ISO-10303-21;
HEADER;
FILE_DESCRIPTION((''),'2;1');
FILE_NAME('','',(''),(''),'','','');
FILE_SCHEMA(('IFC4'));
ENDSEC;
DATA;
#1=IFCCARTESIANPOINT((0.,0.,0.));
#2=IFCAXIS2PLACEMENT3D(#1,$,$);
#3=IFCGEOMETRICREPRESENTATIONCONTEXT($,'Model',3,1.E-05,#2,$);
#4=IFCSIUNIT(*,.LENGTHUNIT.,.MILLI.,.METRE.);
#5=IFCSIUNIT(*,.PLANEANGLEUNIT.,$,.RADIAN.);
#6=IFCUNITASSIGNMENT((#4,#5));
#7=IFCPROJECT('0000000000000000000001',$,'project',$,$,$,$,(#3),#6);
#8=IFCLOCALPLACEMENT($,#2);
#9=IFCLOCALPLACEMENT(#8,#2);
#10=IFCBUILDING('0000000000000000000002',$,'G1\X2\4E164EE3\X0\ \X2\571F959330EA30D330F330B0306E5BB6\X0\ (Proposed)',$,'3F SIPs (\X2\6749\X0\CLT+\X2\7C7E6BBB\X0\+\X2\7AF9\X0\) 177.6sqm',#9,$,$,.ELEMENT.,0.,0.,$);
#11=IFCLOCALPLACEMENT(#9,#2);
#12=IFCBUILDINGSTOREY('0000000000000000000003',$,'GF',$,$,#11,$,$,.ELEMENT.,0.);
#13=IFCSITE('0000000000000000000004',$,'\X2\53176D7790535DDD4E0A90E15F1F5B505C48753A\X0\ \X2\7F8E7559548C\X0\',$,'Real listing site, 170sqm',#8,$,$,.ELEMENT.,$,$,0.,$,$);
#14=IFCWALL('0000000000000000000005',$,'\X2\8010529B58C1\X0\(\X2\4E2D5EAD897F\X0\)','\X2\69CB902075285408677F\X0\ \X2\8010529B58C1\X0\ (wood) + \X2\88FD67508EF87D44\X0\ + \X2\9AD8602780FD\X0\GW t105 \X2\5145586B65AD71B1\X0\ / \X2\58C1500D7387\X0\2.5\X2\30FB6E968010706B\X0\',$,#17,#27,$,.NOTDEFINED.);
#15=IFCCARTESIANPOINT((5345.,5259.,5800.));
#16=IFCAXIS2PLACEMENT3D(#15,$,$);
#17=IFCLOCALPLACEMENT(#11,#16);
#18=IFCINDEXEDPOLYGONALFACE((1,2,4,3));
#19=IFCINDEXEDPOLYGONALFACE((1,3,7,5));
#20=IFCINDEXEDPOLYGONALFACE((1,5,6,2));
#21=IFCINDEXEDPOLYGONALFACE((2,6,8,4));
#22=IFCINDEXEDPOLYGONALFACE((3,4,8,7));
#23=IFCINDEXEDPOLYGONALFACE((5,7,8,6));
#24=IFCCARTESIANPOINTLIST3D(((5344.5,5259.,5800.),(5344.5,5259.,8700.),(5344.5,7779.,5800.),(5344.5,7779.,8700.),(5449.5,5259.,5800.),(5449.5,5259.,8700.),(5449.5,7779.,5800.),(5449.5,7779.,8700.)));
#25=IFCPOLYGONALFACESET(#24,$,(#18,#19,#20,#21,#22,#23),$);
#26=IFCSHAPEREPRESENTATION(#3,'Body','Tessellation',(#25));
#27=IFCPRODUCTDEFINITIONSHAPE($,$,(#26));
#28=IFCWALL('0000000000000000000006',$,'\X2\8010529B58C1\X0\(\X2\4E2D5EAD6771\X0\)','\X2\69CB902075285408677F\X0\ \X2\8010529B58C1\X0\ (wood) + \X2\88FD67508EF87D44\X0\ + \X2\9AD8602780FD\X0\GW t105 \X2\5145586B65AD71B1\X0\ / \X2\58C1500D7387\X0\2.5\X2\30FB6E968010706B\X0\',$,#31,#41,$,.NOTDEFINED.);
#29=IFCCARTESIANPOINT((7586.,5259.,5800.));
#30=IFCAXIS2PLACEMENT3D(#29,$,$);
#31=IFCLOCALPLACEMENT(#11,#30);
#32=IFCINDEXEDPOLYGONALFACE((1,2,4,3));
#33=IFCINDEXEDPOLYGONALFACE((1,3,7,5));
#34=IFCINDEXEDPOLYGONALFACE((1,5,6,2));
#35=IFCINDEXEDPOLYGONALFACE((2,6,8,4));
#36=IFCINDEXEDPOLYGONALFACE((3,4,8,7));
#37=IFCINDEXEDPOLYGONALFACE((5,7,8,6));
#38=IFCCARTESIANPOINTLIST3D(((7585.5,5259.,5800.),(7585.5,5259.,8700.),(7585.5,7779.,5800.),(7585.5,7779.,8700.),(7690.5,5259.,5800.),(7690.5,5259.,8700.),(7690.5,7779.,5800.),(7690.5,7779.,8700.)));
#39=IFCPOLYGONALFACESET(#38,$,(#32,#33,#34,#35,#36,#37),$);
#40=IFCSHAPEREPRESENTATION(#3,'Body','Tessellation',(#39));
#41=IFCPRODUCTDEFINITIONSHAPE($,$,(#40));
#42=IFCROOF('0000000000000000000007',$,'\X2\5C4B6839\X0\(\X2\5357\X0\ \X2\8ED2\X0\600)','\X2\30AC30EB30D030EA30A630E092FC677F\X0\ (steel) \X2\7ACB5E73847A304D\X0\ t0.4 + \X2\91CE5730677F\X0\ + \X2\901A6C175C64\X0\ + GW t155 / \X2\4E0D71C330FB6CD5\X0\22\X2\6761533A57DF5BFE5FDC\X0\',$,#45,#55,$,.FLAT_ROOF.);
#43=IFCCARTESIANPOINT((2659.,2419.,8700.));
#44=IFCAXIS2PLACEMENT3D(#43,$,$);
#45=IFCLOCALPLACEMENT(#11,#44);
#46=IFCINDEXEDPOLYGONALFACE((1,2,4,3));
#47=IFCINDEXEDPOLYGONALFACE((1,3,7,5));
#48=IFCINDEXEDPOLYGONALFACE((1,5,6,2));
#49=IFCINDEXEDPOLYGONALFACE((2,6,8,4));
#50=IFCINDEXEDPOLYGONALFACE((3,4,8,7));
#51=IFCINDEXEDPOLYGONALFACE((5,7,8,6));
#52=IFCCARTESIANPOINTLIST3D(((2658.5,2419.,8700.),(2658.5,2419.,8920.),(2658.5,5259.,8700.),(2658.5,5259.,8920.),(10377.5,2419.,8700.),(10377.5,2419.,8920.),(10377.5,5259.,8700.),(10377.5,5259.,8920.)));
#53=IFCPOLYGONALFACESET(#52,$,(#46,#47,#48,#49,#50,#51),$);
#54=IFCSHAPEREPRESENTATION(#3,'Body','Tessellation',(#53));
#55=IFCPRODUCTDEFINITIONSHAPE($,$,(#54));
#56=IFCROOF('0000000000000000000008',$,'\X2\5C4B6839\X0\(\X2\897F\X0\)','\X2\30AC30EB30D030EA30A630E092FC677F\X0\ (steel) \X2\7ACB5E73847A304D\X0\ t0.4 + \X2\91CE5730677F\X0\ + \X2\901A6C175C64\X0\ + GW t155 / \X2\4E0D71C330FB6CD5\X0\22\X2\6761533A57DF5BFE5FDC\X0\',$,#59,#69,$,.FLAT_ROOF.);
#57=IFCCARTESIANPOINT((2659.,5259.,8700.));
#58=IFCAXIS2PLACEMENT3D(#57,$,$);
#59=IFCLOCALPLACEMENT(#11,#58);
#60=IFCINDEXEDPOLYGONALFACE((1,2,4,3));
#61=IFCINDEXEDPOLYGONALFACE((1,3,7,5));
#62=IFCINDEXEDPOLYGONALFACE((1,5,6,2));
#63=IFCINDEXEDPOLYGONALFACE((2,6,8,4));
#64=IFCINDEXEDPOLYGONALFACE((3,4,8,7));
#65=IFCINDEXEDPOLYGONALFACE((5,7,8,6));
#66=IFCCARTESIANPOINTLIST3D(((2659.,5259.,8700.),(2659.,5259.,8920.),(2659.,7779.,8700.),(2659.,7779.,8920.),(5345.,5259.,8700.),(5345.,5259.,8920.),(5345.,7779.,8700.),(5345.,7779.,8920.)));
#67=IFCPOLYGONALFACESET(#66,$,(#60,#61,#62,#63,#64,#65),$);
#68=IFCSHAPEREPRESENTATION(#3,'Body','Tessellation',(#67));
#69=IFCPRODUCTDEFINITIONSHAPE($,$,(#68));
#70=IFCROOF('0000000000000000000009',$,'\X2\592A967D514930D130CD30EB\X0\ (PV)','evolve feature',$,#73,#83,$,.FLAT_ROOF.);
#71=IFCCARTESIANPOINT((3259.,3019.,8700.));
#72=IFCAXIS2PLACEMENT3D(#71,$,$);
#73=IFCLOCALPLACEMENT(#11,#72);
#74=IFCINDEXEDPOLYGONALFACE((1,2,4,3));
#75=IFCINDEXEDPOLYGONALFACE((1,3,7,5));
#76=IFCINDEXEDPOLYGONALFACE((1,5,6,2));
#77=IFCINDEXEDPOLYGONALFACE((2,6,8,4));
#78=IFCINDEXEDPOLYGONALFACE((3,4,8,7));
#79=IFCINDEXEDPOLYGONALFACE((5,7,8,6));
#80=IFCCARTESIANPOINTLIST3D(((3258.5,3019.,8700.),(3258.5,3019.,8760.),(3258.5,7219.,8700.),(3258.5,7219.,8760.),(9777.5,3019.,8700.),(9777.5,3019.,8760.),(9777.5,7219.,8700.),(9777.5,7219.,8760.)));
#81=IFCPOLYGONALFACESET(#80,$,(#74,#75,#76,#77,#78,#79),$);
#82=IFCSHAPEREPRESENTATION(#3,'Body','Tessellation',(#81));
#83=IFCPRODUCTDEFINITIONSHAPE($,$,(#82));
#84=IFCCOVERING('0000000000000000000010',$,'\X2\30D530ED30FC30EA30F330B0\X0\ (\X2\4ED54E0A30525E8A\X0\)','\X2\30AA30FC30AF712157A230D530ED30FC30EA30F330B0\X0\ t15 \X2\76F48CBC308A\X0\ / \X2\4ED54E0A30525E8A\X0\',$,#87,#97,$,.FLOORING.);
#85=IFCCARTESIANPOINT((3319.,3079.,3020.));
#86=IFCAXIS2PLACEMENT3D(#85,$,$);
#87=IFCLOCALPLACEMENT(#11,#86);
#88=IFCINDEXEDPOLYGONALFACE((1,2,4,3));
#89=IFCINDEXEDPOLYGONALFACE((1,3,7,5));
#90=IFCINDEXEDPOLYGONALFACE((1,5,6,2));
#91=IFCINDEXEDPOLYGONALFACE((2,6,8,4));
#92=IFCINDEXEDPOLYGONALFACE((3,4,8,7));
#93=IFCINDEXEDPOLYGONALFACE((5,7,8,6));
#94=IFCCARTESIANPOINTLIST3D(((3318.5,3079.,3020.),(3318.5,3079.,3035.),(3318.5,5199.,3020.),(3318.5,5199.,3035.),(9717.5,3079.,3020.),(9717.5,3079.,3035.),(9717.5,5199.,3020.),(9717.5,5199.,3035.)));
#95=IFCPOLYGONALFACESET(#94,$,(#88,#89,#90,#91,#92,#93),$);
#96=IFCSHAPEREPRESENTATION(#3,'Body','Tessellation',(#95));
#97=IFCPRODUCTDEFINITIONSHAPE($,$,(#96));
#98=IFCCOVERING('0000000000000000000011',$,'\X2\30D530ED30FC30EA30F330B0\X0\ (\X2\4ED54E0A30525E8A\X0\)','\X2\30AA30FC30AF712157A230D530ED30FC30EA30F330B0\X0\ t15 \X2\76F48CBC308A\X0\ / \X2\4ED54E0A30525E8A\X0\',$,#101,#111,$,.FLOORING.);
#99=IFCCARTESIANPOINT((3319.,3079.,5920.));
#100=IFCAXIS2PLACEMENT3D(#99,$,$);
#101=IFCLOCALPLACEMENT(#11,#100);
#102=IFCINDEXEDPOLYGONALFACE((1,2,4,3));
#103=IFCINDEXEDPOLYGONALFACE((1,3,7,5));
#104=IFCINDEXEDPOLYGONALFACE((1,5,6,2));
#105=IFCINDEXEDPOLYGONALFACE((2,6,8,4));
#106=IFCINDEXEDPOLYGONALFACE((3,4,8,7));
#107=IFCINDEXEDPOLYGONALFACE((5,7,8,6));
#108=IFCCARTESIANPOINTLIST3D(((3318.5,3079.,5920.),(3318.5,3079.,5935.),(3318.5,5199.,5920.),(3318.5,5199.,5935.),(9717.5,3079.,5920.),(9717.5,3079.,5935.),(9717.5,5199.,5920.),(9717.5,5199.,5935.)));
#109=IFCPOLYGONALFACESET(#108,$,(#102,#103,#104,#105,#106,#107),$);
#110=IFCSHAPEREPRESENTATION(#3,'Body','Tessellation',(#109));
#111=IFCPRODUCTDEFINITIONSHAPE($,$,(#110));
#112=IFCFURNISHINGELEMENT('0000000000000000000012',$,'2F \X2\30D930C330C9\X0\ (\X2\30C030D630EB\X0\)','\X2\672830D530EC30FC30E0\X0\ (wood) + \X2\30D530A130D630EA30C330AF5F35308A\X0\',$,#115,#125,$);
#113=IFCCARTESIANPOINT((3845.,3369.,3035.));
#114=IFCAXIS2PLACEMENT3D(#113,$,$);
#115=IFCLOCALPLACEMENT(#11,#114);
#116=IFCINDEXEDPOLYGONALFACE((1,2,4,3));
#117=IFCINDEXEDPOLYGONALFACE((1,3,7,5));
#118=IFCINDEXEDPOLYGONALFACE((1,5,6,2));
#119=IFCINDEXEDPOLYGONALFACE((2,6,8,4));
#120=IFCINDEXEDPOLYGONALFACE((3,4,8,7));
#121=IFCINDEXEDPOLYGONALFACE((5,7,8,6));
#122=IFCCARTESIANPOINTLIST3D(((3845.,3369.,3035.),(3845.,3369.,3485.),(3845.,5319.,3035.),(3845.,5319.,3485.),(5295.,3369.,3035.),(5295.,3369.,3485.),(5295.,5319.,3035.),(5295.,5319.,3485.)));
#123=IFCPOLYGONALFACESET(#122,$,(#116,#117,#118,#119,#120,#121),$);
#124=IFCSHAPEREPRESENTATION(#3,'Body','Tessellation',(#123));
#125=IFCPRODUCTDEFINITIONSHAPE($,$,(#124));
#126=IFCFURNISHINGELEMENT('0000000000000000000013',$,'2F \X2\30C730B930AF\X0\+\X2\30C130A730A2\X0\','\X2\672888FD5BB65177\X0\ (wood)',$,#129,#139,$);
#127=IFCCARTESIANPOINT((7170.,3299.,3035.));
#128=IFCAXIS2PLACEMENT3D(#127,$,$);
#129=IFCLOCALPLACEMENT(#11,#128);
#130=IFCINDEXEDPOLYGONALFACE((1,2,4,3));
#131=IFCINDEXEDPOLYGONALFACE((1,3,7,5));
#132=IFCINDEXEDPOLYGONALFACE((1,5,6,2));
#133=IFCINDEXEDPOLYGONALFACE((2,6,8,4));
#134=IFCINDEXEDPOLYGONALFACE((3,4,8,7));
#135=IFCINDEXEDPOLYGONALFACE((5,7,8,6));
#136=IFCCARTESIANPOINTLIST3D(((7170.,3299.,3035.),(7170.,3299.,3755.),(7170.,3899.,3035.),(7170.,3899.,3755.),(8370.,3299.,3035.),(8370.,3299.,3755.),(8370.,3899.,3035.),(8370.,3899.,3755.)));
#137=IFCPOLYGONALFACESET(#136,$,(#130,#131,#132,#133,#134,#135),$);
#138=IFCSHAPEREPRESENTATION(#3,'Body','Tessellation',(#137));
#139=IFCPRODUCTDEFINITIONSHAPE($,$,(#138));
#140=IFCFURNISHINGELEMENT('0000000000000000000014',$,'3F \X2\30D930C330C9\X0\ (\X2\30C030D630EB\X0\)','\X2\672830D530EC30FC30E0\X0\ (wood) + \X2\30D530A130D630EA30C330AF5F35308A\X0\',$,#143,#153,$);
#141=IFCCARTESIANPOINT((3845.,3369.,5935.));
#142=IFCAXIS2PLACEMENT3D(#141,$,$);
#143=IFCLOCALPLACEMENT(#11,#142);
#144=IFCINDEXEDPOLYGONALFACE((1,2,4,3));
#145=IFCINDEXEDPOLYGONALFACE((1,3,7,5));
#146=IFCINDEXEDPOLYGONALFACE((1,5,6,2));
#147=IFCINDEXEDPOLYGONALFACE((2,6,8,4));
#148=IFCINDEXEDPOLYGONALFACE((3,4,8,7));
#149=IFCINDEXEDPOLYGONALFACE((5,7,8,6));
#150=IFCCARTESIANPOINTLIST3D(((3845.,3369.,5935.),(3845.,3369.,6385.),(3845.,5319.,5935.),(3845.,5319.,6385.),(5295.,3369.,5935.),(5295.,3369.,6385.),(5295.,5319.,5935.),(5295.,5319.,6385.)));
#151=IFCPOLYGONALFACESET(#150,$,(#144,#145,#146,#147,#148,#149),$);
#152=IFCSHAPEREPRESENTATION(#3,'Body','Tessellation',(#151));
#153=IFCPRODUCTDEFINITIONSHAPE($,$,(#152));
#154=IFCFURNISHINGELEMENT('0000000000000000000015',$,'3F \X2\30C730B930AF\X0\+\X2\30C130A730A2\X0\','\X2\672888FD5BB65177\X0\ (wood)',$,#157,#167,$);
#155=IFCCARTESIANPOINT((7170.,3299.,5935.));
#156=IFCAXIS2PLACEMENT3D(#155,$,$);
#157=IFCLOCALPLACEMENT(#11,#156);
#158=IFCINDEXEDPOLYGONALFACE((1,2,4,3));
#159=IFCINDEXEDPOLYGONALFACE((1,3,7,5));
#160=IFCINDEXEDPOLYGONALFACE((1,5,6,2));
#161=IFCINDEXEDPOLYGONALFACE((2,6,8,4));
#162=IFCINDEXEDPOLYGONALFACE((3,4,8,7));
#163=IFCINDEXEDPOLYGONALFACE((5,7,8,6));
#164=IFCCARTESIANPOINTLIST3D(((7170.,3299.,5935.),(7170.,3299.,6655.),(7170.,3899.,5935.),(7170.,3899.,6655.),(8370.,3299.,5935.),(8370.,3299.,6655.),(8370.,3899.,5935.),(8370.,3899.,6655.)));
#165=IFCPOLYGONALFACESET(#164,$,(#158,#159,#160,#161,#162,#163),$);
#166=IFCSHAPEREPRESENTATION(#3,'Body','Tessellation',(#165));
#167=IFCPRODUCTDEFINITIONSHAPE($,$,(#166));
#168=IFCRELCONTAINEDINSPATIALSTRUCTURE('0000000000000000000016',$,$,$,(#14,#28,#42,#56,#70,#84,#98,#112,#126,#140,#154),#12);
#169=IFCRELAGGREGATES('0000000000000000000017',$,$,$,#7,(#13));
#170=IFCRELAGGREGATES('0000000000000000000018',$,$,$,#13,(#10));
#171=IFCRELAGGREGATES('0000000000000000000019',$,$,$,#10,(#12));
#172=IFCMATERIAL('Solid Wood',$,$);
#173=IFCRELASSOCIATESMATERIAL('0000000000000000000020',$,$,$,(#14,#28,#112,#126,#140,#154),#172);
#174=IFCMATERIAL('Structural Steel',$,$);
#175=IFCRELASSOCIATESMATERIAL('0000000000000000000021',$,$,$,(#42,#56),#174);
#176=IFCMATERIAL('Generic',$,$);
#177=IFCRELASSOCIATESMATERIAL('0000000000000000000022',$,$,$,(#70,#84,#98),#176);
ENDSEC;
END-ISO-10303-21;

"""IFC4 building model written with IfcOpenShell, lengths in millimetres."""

from ifc_helpers import new_model, si_unit, frame, frame_2d, origin, place, context, project, spatial, rectangle, extrude, material, element, save


model = new_model("IFC4")

# Units and contexts
model_context = context("Model", 3, precision=1e-05, world=origin())
ifc_project = project(units=[si_unit("LENGTHUNIT", "METRE", prefix="MILLI"), si_unit("PLANEANGLEUNIT", "RADIAN")], contexts=[model_context])

# Site, building, storey
site_placement = place(None, origin())
site = spatial("IfcSite", under=ifc_project, at=site_placement, Name="北海道川上郡弟子屈町 美留和", ObjectType="Real listing site, 170sqm", CompositionType="ELEMENT", RefElevation=0.0)
building_placement = place(site_placement, origin())
building = spatial("IfcBuilding", under=site, at=building_placement, Name="G1世代 土間リビングの家 (Proposed)", ObjectType="3F SIPs (杉CLT+籾殻+竹) 177.6sqm", CompositionType="ELEMENT", ElevationOfRefHeight=0.0, ElevationOfTerrain=0.0)
storey_placement = place(building_placement, origin())
storey = spatial("IfcBuildingStorey", under=building, at=storey_placement, Name="GF", CompositionType="ELEMENT", Elevation=0.0)

# Shared definitions
ifc_material_1 = material(Name="Solid Wood")

# Walls
wall_1_placement = place(storey_placement, frame((5345.0, 5259.0, 5800.0)))
element("IfcWall", 1, at=wall_1_placement, inside=storey, material=ifc_material_1, Name="耐力壁(中庭西)", Description="構造用合板 耐力壁 (wood) + 製材軸組 + 高性能GW t105 充填断熱 / 壁倍率2.5・準耐火", PredefinedType="NOTDEFINED", context=model_context, shape_type="SweptSolid", body=[
    extrude(rectangle(XDim=105.0, YDim=2520.0, at=frame_2d((52.0, 1260.0))), frame((5345.0, 5259.0, 5800.0)), (0.0, 0.0, 1.0), 2900.0),
])
wall_2_placement = place(storey_placement, frame((7586.0, 5259.0, 5800.0)))
element("IfcWall", 2, at=wall_2_placement, inside=storey, material=ifc_material_1, Name="耐力壁(中庭東)", Description="構造用合板 耐力壁 (wood) + 製材軸組 + 高性能GW t105 充填断熱 / 壁倍率2.5・準耐火", PredefinedType="NOTDEFINED", context=model_context, shape_type="SweptSolid", body=[
    extrude(rectangle(XDim=105.0, YDim=2520.0, at=frame_2d((52.0, 1260.0))), frame((7586.0, 5259.0, 5800.0)), (0.0, 0.0, 1.0), 2900.0),
])

# Roofs
ifc_material_2 = material(Name="Structural Steel")
roof_1_placement = place(storey_placement, frame((2659.0, 2419.0, 8700.0)))
element("IfcRoof", 3, at=roof_1_placement, inside=storey, material=ifc_material_2, Name="屋根(南 軒600)", Description="ガルバリウム鋼板 (steel) 立平葺き t0.4 + 野地板 + 通気層 + GW t155 / 不燃・法22条区域対応", PredefinedType="FLAT_ROOF", context=model_context, shape_type="SweptSolid", body=[
    extrude(rectangle(XDim=7719.0, YDim=2840.0, at=frame_2d((3859.0, 1420.0))), frame((2659.0, 2419.0, 8700.0)), (0.0, 0.0, 1.0), 220.0),
])
roof_2_placement = place(storey_placement, frame((2659.0, 5259.0, 8700.0)))
element("IfcRoof", 4, at=roof_2_placement, inside=storey, material=ifc_material_2, Name="屋根(西)", Description="ガルバリウム鋼板 (steel) 立平葺き t0.4 + 野地板 + 通気層 + GW t155 / 不燃・法22条区域対応", PredefinedType="FLAT_ROOF", context=model_context, shape_type="SweptSolid", body=[
    extrude(rectangle(XDim=2686.0, YDim=2520.0, at=frame_2d((1343.0, 1260.0))), frame((2659.0, 5259.0, 8700.0)), (0.0, 0.0, 1.0), 220.0),
])
ifc_material_3 = material(Name="Generic")
roof_3_placement = place(storey_placement, frame((3259.0, 3019.0, 8700.0)))
element("IfcRoof", 5, at=roof_3_placement, inside=storey, material=ifc_material_3, Name="太陽光パネル (PV)", Description="evolve feature", PredefinedType="FLAT_ROOF", context=model_context, shape_type="SweptSolid", body=[
    extrude(rectangle(XDim=6519.0, YDim=4200.0, at=frame_2d((3259.0, 2100.0))), frame((3259.0, 3019.0, 8700.0)), (0.0, 0.0, 1.0), 60.0),
])

# Coverings
covering_1_placement = place(storey_placement, frame((3319.0, 3079.0, 3020.0)))
element("IfcCovering", 6, at=covering_1_placement, inside=storey, material=ifc_material_3, Name="フローリング (仕上げ床)", Description="オーク無垢フローリング t15 直貼り / 仕上げ床", PredefinedType="FLOORING", context=model_context, shape_type="SweptSolid", body=[
    extrude(rectangle(XDim=6399.0, YDim=2120.0, at=frame_2d((3199.0, 1060.0))), frame((3319.0, 3079.0, 3020.0)), (0.0, 0.0, 1.0), 15.0),
])
covering_2_placement = place(storey_placement, frame((3319.0, 3079.0, 5920.0)))
element("IfcCovering", 7, at=covering_2_placement, inside=storey, material=ifc_material_3, Name="フローリング (仕上げ床)", Description="オーク無垢フローリング t15 直貼り / 仕上げ床", PredefinedType="FLOORING", context=model_context, shape_type="SweptSolid", body=[
    extrude(rectangle(XDim=6399.0, YDim=2120.0, at=frame_2d((3199.0, 1060.0))), frame((3319.0, 3079.0, 5920.0)), (0.0, 0.0, 1.0), 15.0),
])

# Furnishing elements
furnishing_1_placement = place(storey_placement, frame((3845.0, 3369.0, 3035.0)))
element("IfcFurnishingElement", 8, at=furnishing_1_placement, inside=storey, material=ifc_material_1, Name="2F ベッド (ダブル)", Description="木フレーム (wood) + ファブリック張り", context=model_context, shape_type="SweptSolid", body=[
    extrude(rectangle(XDim=1450.0, YDim=1950.0, at=frame_2d((725.0, 975.0))), frame((3845.0, 3369.0, 3035.0)), (0.0, 0.0, 1.0), 450.0),
])
furnishing_2_placement = place(storey_placement, frame((7170.0, 3299.0, 3035.0)))
element("IfcFurnishingElement", 9, at=furnishing_2_placement, inside=storey, material=ifc_material_1, Name="2F デスク+チェア", Description="木製家具 (wood)", context=model_context, shape_type="SweptSolid", body=[
    extrude(rectangle(XDim=1200.0, YDim=600.0, at=frame_2d((600.0, 300.0))), frame((7170.0, 3299.0, 3035.0)), (0.0, 0.0, 1.0), 720.0),
])
furnishing_3_placement = place(storey_placement, frame((3845.0, 3369.0, 5935.0)))
element("IfcFurnishingElement", 10, at=furnishing_3_placement, inside=storey, material=ifc_material_1, Name="3F ベッド (ダブル)", Description="木フレーム (wood) + ファブリック張り", context=model_context, shape_type="SweptSolid", body=[
    extrude(rectangle(XDim=1450.0, YDim=1950.0, at=frame_2d((725.0, 975.0))), frame((3845.0, 3369.0, 5935.0)), (0.0, 0.0, 1.0), 450.0),
])
furnishing_4_placement = place(storey_placement, frame((7170.0, 3299.0, 5935.0)))
element("IfcFurnishingElement", 11, at=furnishing_4_placement, inside=storey, material=ifc_material_1, Name="3F デスク+チェア", Description="木製家具 (wood)", context=model_context, shape_type="SweptSolid", body=[
    extrude(rectangle(XDim=1200.0, YDim=600.0, at=frame_2d((600.0, 300.0))), frame((7170.0, 3299.0, 5935.0)), (0.0, 0.0, 1.0), 720.0),
])

save(model, "model.ifc")
